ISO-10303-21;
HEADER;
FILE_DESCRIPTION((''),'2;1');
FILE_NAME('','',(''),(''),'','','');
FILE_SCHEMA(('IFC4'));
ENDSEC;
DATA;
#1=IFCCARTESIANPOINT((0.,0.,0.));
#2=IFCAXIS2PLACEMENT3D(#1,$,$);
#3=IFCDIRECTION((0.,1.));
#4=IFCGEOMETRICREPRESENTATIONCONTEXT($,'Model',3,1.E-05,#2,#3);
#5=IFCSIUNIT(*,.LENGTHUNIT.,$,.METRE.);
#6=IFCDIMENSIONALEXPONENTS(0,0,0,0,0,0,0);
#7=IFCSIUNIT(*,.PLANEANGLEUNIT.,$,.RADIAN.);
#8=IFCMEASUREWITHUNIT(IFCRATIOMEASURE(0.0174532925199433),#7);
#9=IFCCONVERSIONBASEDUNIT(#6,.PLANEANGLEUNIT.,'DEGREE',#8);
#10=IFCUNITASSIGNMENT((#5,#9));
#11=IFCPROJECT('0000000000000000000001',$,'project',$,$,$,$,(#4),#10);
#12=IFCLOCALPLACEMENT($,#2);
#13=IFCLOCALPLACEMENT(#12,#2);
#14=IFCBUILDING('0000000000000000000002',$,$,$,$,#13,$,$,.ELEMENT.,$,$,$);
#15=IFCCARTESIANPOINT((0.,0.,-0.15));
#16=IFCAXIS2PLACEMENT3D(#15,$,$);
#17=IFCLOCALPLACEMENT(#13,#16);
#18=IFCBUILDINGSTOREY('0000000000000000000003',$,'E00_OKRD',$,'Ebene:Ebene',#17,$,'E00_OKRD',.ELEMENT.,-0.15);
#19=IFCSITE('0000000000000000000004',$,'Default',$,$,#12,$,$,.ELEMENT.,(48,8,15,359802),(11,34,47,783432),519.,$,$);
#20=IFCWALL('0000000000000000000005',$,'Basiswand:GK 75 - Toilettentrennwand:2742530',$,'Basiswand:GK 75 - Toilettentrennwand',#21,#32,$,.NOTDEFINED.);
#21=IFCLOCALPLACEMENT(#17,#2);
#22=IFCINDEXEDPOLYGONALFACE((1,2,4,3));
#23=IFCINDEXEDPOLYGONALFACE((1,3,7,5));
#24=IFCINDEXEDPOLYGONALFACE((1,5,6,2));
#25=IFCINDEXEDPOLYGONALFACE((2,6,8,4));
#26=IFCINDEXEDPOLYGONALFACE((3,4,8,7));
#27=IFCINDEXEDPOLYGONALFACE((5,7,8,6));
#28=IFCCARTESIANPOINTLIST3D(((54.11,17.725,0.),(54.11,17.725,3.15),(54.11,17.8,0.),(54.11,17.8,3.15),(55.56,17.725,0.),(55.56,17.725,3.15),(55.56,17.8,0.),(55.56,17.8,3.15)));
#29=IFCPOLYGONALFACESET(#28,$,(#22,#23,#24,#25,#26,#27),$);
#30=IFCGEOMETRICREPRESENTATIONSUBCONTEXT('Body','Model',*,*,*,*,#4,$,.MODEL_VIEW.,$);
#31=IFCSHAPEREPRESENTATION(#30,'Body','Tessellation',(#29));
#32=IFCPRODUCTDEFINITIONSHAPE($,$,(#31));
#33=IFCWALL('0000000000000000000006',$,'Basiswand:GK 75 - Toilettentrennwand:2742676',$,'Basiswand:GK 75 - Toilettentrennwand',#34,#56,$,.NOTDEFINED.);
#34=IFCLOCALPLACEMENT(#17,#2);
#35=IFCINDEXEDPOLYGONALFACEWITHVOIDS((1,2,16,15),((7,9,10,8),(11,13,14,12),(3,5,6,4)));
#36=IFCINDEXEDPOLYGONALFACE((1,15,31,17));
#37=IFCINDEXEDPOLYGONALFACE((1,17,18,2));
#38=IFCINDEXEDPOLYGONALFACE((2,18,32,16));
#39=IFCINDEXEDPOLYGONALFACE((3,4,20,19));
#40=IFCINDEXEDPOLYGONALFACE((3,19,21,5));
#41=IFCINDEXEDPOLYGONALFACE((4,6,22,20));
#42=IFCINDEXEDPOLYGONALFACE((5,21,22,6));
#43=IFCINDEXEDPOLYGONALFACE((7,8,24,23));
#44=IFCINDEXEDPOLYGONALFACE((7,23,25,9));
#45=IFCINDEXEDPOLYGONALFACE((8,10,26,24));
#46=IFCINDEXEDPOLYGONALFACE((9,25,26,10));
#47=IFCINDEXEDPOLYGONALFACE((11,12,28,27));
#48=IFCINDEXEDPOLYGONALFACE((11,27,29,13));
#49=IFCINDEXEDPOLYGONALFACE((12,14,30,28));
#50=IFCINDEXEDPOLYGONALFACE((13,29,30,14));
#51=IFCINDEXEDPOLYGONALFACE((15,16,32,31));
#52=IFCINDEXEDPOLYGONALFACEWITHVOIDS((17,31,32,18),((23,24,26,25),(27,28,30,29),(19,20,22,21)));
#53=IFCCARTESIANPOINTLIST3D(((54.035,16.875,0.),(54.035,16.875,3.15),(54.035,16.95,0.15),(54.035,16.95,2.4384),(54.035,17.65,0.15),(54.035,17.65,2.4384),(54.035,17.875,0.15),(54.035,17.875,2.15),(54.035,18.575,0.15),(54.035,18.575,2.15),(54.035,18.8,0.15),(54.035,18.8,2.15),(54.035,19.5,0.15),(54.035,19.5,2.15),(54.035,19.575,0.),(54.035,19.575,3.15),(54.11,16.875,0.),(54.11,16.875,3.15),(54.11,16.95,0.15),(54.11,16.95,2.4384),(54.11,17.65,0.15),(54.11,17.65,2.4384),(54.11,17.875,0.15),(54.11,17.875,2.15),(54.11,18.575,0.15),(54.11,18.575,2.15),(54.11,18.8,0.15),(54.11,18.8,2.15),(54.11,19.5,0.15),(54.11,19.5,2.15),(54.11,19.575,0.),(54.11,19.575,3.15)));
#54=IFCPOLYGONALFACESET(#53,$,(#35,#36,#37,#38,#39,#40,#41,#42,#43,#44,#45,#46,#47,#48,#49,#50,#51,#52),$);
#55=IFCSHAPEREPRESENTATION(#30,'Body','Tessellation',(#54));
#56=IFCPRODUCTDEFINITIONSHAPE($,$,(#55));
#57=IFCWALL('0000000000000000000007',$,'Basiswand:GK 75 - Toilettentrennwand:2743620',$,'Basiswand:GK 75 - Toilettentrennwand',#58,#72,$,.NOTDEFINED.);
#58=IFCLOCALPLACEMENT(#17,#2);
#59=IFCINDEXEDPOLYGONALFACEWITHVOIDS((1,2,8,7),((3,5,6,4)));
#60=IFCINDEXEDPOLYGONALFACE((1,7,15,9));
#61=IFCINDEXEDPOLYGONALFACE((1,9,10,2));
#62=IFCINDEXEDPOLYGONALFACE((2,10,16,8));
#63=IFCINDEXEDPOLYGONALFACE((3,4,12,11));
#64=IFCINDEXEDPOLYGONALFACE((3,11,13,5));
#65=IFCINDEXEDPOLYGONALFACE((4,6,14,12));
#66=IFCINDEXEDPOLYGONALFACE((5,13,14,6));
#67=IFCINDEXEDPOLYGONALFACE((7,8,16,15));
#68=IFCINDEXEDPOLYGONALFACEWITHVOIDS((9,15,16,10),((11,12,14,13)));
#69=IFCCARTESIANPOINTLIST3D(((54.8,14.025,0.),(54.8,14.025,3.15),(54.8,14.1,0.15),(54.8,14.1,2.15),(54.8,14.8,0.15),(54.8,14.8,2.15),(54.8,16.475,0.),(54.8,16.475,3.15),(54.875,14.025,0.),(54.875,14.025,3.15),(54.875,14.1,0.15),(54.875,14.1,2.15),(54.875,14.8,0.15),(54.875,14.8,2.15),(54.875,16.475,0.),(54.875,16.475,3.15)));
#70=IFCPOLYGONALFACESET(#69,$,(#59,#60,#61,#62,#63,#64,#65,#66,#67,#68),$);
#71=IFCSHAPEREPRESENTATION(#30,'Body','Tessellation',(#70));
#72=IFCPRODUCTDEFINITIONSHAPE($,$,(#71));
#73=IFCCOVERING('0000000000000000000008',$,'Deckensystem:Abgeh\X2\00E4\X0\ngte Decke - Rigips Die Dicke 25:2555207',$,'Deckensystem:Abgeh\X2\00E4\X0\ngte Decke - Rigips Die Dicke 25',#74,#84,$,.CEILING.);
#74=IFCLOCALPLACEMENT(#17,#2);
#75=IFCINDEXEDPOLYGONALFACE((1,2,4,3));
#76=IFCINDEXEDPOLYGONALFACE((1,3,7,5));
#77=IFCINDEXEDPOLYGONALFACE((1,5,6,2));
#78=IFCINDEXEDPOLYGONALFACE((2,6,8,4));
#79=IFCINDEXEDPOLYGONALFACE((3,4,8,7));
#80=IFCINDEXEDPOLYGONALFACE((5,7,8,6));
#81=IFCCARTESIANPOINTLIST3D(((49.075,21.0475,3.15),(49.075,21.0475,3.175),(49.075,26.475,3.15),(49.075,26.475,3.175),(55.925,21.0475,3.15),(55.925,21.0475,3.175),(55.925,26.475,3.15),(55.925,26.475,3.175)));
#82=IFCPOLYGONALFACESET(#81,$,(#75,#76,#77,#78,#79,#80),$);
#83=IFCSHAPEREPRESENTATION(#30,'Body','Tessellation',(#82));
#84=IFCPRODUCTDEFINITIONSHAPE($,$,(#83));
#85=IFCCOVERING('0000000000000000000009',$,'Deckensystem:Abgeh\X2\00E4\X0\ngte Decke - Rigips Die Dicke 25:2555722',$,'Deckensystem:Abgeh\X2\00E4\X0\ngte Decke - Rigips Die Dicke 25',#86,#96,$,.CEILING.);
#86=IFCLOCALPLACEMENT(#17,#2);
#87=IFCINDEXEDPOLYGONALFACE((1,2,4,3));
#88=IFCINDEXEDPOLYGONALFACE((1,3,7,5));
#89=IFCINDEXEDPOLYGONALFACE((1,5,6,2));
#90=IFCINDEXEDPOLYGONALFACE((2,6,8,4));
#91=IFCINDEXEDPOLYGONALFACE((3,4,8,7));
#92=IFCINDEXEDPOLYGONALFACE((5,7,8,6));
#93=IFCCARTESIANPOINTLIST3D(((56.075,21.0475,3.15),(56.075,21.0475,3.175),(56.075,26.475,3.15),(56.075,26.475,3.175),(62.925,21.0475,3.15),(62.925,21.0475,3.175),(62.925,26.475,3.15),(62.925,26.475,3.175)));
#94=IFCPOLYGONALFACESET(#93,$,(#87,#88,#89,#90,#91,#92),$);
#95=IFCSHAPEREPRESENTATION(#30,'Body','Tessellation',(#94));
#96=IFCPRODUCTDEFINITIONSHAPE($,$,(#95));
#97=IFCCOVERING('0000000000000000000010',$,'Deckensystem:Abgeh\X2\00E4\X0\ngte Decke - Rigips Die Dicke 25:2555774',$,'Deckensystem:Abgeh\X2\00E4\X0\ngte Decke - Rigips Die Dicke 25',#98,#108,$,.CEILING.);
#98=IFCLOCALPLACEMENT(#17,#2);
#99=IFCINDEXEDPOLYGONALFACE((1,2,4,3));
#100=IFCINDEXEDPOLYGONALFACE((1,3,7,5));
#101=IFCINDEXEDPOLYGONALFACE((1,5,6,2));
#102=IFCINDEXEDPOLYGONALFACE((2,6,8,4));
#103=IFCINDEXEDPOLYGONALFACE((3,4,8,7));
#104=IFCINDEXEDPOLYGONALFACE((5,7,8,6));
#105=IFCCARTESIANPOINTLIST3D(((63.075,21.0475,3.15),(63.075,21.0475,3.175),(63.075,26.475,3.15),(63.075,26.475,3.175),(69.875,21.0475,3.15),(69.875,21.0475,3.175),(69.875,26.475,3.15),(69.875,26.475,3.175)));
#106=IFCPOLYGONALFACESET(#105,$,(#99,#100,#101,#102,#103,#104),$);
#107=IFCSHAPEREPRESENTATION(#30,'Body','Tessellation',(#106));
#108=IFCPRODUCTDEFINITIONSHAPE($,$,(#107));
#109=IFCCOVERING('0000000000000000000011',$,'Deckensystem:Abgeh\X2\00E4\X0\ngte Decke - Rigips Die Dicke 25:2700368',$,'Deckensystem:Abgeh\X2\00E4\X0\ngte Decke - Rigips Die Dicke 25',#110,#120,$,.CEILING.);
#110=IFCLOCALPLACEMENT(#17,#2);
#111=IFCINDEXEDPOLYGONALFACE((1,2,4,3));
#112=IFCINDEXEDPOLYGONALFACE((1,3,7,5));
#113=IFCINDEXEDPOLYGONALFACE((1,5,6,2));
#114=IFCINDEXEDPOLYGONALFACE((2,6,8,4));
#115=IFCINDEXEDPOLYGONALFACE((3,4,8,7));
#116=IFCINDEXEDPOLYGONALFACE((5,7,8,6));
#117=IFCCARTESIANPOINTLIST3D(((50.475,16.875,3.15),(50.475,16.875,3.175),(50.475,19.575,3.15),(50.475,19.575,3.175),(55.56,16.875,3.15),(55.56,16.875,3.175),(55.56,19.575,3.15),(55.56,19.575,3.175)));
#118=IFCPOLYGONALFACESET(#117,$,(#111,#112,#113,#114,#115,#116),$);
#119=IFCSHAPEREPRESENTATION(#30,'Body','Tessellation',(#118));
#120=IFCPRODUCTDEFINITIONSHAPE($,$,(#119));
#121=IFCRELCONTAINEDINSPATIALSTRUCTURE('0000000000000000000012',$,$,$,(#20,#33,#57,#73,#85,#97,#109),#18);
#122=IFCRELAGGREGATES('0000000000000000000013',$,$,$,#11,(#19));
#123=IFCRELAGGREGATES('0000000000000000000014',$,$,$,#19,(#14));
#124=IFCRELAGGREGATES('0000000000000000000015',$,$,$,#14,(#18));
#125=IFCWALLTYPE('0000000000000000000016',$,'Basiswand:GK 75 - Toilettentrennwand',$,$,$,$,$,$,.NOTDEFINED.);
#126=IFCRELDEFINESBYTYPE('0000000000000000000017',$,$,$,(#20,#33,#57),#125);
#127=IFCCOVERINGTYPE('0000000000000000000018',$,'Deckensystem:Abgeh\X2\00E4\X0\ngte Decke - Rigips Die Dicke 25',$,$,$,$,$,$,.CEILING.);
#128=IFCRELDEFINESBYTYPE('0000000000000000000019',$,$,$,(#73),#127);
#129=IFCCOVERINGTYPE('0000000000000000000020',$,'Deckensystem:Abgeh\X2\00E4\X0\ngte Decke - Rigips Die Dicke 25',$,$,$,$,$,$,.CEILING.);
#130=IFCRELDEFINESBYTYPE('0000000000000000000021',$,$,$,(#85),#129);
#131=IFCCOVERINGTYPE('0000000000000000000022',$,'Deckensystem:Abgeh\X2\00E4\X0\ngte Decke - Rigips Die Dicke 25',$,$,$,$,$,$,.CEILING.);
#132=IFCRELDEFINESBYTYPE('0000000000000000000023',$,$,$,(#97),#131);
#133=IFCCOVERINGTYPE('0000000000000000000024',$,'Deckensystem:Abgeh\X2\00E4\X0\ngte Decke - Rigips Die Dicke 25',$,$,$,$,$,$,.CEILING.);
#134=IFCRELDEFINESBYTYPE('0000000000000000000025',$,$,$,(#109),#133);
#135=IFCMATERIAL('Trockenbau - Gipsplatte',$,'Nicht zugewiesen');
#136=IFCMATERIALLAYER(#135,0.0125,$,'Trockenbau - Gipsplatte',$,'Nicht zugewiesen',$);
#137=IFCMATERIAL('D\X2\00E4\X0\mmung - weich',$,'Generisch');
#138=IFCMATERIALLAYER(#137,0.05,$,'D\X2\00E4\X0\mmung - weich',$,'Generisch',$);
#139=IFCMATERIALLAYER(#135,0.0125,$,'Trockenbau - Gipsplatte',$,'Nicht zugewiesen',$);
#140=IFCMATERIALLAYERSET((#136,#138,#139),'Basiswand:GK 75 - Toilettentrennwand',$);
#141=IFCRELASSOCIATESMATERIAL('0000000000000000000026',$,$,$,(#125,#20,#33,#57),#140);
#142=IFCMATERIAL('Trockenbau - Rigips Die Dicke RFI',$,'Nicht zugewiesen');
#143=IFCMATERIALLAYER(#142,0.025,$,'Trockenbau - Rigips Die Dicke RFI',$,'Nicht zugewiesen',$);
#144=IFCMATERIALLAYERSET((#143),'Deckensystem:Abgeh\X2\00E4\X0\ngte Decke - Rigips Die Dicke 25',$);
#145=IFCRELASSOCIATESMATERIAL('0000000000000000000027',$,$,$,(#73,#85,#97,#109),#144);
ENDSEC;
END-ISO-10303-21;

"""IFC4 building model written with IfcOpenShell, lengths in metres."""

from ifc_helpers import new_model, entity, si_unit, converted_unit, direction, frame, frame_2d, origin, origin_2d_with_axis, place, context, subcontext, project, spatial, rectangle, extrude, material, layer, layer_set, layer_usage, type_object, element, save


model = new_model("IFC4")

# Units and contexts
model_context = context("Model", 3, precision=1e-05, world=origin(), true_north=direction((0.0, 1.0)))
body_context = subcontext(model_context, "Body", "Model", "MODEL_VIEW")
ifc_project = project(units=[si_unit("LENGTHUNIT", "METRE"), converted_unit("PLANEANGLEUNIT", "DEGREE", entity("IfcRatioMeasure", 0.0174532925199433), si_unit("PLANEANGLEUNIT", "RADIAN"), dimensions=[0, 0, 0, 0, 0, 0, 0])], contexts=[model_context])

# Site, building, storey
site_placement = place(None, frame((0.0, 0.0, 0.0)))
site = spatial("IfcSite", under=ifc_project, at=site_placement, Name="Default", CompositionType="ELEMENT", RefLatitude=(48, 8, 15, 359802), RefLongitude=(11, 34, 47, 783432), RefElevation=519.0)
building_placement = place(site_placement, origin())
building = spatial("IfcBuilding", under=site, at=building_placement, CompositionType="ELEMENT")
storey_placement = place(building_placement, frame((0.0, 0.0, -0.15)))
storey = spatial("IfcBuildingStorey", under=building, at=storey_placement, Name="E00_OKRD", ObjectType="Ebene:Ebene", LongName="E00_OKRD", CompositionType="ELEMENT", Elevation=-0.15)

# Wall
ifc_material_1 = material(Name="Trockenbau - Gipsplatte", Category="Nicht zugewiesen")
ifc_material_2 = material(Name="Dämmung - weich", Category="Generisch")
ifc_layer_1 = layer(ifc_material_1, 0.0125, Name="Trockenbau - Gipsplatte", Category="Nicht zugewiesen")
ifc_layer_2 = layer(ifc_material_2, 0.05, Name="Dämmung - weich", Category="Generisch")
ifc_layer_3 = layer(ifc_material_1, 0.0125, Name="Trockenbau - Gipsplatte", Category="Nicht zugewiesen")
ifc_layer_set_1 = layer_set([ifc_layer_1, ifc_layer_2, ifc_layer_3], Name="Basiswand:GK 75 - Toilettentrennwand")
wall_type_1 = type_object("IfcWallType", Name="Basiswand:GK 75 - Toilettentrennwand", PredefinedType="NOTDEFINED", material=ifc_layer_set_1)
ifc_layer_usage_1 = layer_usage(ifc_layer_set_1, "AXIS2", "NEGATIVE", 0.0375)
wall_1_placement = place(storey_placement, frame((55.56, 17.7625, 0.0), z_axis=(0.0, 0.0, 1.0), x_axis=(-1.0, 0.0, 0.0)))
element("IfcWall", 1, at=wall_1_placement, inside=storey, type_object=wall_type_1, material=ifc_layer_usage_1, Name="Basiswand:GK 75 - Toilettentrennwand:2742530", ObjectType="Basiswand:GK 75 - Toilettentrennwand", PredefinedType="NOTDEFINED", context=body_context, shape_type="SweptSolid", body=[
    extrude(rectangle(XDim=1.45, YDim=0.075, at=frame_2d((0.725, 0.0), x_axis=(-1.0, 0.0))), origin(), (0.0, 0.0, 1.0), 3.15),
])

# Wall, openings
ifc_layer_usage_2 = layer_usage(ifc_layer_set_1, "AXIS2", "NEGATIVE", 0.0375)
wall_2_placement = place(storey_placement, frame((54.0725, 19.575, 0.0), z_axis=(0.0, 0.0, 1.0), x_axis=(0.0, -1.0, 0.0)))
wall_2 = element("IfcWall", 2, at=wall_2_placement, inside=storey, type_object=wall_type_1, material=ifc_layer_usage_2, Name="Basiswand:GK 75 - Toilettentrennwand:2742676", ObjectType="Basiswand:GK 75 - Toilettentrennwand", PredefinedType="NOTDEFINED", context=body_context, shape_type="SweptSolid", body=[
    extrude(rectangle(XDim=2.7, YDim=0.075, at=frame_2d((1.35, 0.0), x_axis=(-1.0, 0.0))), origin(), (0.0, 0.0, 1.0), 3.15),
])
opening_1_placement = place(wall_2_placement, frame((0.775, -0.0375, 0.15)))
element("IfcOpeningElement", 3, at=opening_1_placement, cuts=wall_2, ObjectType="Opening", PredefinedType="OPENING", context=body_context, shape_type="SweptSolid", body=[
    extrude(rectangle(XDim=2.0, YDim=0.7, at=origin_2d_with_axis()), frame((-0.35, 0.0, 1.0), z_axis=(0.0, 1.0, 0.0), x_axis=(0.0, 0.0, -1.0)), (0.0, 0.0, 1.0), 0.075),
])
opening_2_placement = place(wall_2_placement, frame((1.7, -0.0375, 0.15)))
element("IfcOpeningElement", 4, at=opening_2_placement, cuts=wall_2, ObjectType="Opening", PredefinedType="OPENING", context=body_context, shape_type="SweptSolid", body=[
    extrude(rectangle(XDim=2.0, YDim=0.7, at=frame_2d((0.0, 0.0), x_axis=(1.0, 0.0))), frame((-0.35, 0.0, 1.0), z_axis=(0.0, 1.0, 0.0), x_axis=(0.0, 0.0, -1.0)), (0.0, 0.0, 1.0), 0.075),
])
opening_3_placement = place(wall_2_placement, frame((2.625, -0.0375, 0.15)))
element("IfcOpeningElement", 5, at=opening_3_placement, cuts=wall_2, ObjectType="Opening", PredefinedType="OPENING", context=body_context, shape_type="SweptSolid", body=[
    extrude(rectangle(XDim=2.2884, YDim=0.7, at=frame_2d((0.0, 0.0), x_axis=(1.0, 0.0))), frame((-0.35, 0.0, 1.1442), z_axis=(0.0, 1.0, 0.0), x_axis=(0.0, 0.0, -1.0)), (0.0, 0.0, 1.0), 0.075),
])

# Wall, opening
ifc_layer_usage_3 = layer_usage(ifc_layer_set_1, "AXIS2", "NEGATIVE", 0.0375)
wall_3_placement = place(storey_placement, frame((54.8375, 16.475, 0.0), z_axis=(0.0, 0.0, 1.0), x_axis=(0.0, -1.0, 0.0)))
wall_3 = element("IfcWall", 6, at=wall_3_placement, inside=storey, type_object=wall_type_1, material=ifc_layer_usage_3, Name="Basiswand:GK 75 - Toilettentrennwand:2743620", ObjectType="Basiswand:GK 75 - Toilettentrennwand", PredefinedType="NOTDEFINED", context=body_context, shape_type="SweptSolid", body=[
    extrude(rectangle(XDim=2.45, YDim=0.075, at=frame_2d((1.225, 0.0), x_axis=(-1.0, 0.0))), origin(), (0.0, 0.0, 1.0), 3.15),
])
opening_4_placement = place(wall_3_placement, frame((2.375, -0.0375, 0.15)))
element("IfcOpeningElement", 7, at=opening_4_placement, cuts=wall_3, ObjectType="Opening", PredefinedType="OPENING", context=body_context, shape_type="SweptSolid", body=[
    extrude(rectangle(XDim=2.0, YDim=0.7, at=origin_2d_with_axis()), frame((-0.35, 0.0, 1.0), z_axis=(0.0, 1.0, 0.0), x_axis=(0.0, 0.0, -1.0)), (0.0, 0.0, 1.0), 0.075),
])

# Coverings
ifc_material_3 = material(Name="Trockenbau - Rigips Die Dicke RFI", Category="Nicht zugewiesen")
ifc_layer_4 = layer(ifc_material_3, 0.025, Name="Trockenbau - Rigips Die Dicke RFI", Category="Nicht zugewiesen")
ifc_layer_set_2 = layer_set([ifc_layer_4], Name="Deckensystem:Abgehängte Decke - Rigips Die Dicke 25")
ifc_layer_usage_4 = layer_usage(ifc_layer_set_2, "AXIS3", "POSITIVE", 0.0)
covering_type_1 = type_object("IfcCoveringType", Name="Deckensystem:Abgehängte Decke - Rigips Die Dicke 25", PredefinedType="CEILING")
covering_1_placement = place(storey_placement, frame((49.075, 21.0475, 3.15)))
element("IfcCovering", 8, at=covering_1_placement, inside=storey, type_object=covering_type_1, material=ifc_layer_usage_4, Name="Deckensystem:Abgehängte Decke - Rigips Die Dicke 25:2555207", ObjectType="Deckensystem:Abgehängte Decke - Rigips Die Dicke 25", PredefinedType="CEILING", context=body_context, shape_type="SweptSolid", body=[
    extrude(rectangle(XDim=6.85, YDim=5.4275, at=frame_2d((0.0, 0.0), x_axis=(1.0, 0.0))), frame((3.425, 2.7137, 0.0)), (0.0, 0.0, 1.0), 0.025),
])
ifc_layer_usage_5 = layer_usage(ifc_layer_set_2, "AXIS3", "POSITIVE", 0.0)
covering_type_2 = type_object("IfcCoveringType", Name="Deckensystem:Abgehängte Decke - Rigips Die Dicke 25", PredefinedType="CEILING")
covering_2_placement = place(storey_placement, frame((56.075, 21.0475, 3.15)))
element("IfcCovering", 9, at=covering_2_placement, inside=storey, type_object=covering_type_2, material=ifc_layer_usage_5, Name="Deckensystem:Abgehängte Decke - Rigips Die Dicke 25:2555722", ObjectType="Deckensystem:Abgehängte Decke - Rigips Die Dicke 25", PredefinedType="CEILING", context=body_context, shape_type="SweptSolid", body=[
    extrude(rectangle(XDim=6.85, YDim=5.4275, at=frame_2d((0.0, 0.0), x_axis=(1.0, 0.0))), frame((3.425, 2.7137, 0.0), z_axis=(0.0, 0.0, 1.0), x_axis=(-1.0, 0.0, 0.0)), (0.0, 0.0, 1.0), 0.025),
])
ifc_layer_usage_6 = layer_usage(ifc_layer_set_2, "AXIS3", "POSITIVE", 0.0)
covering_type_3 = type_object("IfcCoveringType", Name="Deckensystem:Abgehängte Decke - Rigips Die Dicke 25", PredefinedType="CEILING")
covering_3_placement = place(storey_placement, frame((63.075, 21.0475, 3.15)))
element("IfcCovering", 10, at=covering_3_placement, inside=storey, type_object=covering_type_3, material=ifc_layer_usage_6, Name="Deckensystem:Abgehängte Decke - Rigips Die Dicke 25:2555774", ObjectType="Deckensystem:Abgehängte Decke - Rigips Die Dicke 25", PredefinedType="CEILING", context=body_context, shape_type="SweptSolid", body=[
    extrude(rectangle(XDim=6.8, YDim=5.4275, at=origin_2d_with_axis()), frame((3.4, 2.7137, 0.0), z_axis=(0.0, 0.0, 1.0), x_axis=(-1.0, 0.0, 0.0)), (0.0, 0.0, 1.0), 0.025),
])
ifc_layer_usage_7 = layer_usage(ifc_layer_set_2, "AXIS3", "POSITIVE", 0.0)
covering_type_4 = type_object("IfcCoveringType", Name="Deckensystem:Abgehängte Decke - Rigips Die Dicke 25", PredefinedType="CEILING")
covering_4_placement = place(storey_placement, frame((50.475, 16.875, 3.15)))
element("IfcCovering", 11, at=covering_4_placement, inside=storey, type_object=covering_type_4, material=ifc_layer_usage_7, Name="Deckensystem:Abgehängte Decke - Rigips Die Dicke 25:2700368", ObjectType="Deckensystem:Abgehängte Decke - Rigips Die Dicke 25", PredefinedType="CEILING", context=body_context, shape_type="SweptSolid", body=[
    extrude(rectangle(XDim=5.085, YDim=2.7, at=frame_2d((0.0, 0.0), x_axis=(1.0, 0.0))), frame((2.5425, 1.35, 0.0), z_axis=(0.0, 0.0, 1.0), x_axis=(-1.0, 0.0, 0.0)), (0.0, 0.0, 1.0), 0.025),
])

save(model, "model.ifc")
